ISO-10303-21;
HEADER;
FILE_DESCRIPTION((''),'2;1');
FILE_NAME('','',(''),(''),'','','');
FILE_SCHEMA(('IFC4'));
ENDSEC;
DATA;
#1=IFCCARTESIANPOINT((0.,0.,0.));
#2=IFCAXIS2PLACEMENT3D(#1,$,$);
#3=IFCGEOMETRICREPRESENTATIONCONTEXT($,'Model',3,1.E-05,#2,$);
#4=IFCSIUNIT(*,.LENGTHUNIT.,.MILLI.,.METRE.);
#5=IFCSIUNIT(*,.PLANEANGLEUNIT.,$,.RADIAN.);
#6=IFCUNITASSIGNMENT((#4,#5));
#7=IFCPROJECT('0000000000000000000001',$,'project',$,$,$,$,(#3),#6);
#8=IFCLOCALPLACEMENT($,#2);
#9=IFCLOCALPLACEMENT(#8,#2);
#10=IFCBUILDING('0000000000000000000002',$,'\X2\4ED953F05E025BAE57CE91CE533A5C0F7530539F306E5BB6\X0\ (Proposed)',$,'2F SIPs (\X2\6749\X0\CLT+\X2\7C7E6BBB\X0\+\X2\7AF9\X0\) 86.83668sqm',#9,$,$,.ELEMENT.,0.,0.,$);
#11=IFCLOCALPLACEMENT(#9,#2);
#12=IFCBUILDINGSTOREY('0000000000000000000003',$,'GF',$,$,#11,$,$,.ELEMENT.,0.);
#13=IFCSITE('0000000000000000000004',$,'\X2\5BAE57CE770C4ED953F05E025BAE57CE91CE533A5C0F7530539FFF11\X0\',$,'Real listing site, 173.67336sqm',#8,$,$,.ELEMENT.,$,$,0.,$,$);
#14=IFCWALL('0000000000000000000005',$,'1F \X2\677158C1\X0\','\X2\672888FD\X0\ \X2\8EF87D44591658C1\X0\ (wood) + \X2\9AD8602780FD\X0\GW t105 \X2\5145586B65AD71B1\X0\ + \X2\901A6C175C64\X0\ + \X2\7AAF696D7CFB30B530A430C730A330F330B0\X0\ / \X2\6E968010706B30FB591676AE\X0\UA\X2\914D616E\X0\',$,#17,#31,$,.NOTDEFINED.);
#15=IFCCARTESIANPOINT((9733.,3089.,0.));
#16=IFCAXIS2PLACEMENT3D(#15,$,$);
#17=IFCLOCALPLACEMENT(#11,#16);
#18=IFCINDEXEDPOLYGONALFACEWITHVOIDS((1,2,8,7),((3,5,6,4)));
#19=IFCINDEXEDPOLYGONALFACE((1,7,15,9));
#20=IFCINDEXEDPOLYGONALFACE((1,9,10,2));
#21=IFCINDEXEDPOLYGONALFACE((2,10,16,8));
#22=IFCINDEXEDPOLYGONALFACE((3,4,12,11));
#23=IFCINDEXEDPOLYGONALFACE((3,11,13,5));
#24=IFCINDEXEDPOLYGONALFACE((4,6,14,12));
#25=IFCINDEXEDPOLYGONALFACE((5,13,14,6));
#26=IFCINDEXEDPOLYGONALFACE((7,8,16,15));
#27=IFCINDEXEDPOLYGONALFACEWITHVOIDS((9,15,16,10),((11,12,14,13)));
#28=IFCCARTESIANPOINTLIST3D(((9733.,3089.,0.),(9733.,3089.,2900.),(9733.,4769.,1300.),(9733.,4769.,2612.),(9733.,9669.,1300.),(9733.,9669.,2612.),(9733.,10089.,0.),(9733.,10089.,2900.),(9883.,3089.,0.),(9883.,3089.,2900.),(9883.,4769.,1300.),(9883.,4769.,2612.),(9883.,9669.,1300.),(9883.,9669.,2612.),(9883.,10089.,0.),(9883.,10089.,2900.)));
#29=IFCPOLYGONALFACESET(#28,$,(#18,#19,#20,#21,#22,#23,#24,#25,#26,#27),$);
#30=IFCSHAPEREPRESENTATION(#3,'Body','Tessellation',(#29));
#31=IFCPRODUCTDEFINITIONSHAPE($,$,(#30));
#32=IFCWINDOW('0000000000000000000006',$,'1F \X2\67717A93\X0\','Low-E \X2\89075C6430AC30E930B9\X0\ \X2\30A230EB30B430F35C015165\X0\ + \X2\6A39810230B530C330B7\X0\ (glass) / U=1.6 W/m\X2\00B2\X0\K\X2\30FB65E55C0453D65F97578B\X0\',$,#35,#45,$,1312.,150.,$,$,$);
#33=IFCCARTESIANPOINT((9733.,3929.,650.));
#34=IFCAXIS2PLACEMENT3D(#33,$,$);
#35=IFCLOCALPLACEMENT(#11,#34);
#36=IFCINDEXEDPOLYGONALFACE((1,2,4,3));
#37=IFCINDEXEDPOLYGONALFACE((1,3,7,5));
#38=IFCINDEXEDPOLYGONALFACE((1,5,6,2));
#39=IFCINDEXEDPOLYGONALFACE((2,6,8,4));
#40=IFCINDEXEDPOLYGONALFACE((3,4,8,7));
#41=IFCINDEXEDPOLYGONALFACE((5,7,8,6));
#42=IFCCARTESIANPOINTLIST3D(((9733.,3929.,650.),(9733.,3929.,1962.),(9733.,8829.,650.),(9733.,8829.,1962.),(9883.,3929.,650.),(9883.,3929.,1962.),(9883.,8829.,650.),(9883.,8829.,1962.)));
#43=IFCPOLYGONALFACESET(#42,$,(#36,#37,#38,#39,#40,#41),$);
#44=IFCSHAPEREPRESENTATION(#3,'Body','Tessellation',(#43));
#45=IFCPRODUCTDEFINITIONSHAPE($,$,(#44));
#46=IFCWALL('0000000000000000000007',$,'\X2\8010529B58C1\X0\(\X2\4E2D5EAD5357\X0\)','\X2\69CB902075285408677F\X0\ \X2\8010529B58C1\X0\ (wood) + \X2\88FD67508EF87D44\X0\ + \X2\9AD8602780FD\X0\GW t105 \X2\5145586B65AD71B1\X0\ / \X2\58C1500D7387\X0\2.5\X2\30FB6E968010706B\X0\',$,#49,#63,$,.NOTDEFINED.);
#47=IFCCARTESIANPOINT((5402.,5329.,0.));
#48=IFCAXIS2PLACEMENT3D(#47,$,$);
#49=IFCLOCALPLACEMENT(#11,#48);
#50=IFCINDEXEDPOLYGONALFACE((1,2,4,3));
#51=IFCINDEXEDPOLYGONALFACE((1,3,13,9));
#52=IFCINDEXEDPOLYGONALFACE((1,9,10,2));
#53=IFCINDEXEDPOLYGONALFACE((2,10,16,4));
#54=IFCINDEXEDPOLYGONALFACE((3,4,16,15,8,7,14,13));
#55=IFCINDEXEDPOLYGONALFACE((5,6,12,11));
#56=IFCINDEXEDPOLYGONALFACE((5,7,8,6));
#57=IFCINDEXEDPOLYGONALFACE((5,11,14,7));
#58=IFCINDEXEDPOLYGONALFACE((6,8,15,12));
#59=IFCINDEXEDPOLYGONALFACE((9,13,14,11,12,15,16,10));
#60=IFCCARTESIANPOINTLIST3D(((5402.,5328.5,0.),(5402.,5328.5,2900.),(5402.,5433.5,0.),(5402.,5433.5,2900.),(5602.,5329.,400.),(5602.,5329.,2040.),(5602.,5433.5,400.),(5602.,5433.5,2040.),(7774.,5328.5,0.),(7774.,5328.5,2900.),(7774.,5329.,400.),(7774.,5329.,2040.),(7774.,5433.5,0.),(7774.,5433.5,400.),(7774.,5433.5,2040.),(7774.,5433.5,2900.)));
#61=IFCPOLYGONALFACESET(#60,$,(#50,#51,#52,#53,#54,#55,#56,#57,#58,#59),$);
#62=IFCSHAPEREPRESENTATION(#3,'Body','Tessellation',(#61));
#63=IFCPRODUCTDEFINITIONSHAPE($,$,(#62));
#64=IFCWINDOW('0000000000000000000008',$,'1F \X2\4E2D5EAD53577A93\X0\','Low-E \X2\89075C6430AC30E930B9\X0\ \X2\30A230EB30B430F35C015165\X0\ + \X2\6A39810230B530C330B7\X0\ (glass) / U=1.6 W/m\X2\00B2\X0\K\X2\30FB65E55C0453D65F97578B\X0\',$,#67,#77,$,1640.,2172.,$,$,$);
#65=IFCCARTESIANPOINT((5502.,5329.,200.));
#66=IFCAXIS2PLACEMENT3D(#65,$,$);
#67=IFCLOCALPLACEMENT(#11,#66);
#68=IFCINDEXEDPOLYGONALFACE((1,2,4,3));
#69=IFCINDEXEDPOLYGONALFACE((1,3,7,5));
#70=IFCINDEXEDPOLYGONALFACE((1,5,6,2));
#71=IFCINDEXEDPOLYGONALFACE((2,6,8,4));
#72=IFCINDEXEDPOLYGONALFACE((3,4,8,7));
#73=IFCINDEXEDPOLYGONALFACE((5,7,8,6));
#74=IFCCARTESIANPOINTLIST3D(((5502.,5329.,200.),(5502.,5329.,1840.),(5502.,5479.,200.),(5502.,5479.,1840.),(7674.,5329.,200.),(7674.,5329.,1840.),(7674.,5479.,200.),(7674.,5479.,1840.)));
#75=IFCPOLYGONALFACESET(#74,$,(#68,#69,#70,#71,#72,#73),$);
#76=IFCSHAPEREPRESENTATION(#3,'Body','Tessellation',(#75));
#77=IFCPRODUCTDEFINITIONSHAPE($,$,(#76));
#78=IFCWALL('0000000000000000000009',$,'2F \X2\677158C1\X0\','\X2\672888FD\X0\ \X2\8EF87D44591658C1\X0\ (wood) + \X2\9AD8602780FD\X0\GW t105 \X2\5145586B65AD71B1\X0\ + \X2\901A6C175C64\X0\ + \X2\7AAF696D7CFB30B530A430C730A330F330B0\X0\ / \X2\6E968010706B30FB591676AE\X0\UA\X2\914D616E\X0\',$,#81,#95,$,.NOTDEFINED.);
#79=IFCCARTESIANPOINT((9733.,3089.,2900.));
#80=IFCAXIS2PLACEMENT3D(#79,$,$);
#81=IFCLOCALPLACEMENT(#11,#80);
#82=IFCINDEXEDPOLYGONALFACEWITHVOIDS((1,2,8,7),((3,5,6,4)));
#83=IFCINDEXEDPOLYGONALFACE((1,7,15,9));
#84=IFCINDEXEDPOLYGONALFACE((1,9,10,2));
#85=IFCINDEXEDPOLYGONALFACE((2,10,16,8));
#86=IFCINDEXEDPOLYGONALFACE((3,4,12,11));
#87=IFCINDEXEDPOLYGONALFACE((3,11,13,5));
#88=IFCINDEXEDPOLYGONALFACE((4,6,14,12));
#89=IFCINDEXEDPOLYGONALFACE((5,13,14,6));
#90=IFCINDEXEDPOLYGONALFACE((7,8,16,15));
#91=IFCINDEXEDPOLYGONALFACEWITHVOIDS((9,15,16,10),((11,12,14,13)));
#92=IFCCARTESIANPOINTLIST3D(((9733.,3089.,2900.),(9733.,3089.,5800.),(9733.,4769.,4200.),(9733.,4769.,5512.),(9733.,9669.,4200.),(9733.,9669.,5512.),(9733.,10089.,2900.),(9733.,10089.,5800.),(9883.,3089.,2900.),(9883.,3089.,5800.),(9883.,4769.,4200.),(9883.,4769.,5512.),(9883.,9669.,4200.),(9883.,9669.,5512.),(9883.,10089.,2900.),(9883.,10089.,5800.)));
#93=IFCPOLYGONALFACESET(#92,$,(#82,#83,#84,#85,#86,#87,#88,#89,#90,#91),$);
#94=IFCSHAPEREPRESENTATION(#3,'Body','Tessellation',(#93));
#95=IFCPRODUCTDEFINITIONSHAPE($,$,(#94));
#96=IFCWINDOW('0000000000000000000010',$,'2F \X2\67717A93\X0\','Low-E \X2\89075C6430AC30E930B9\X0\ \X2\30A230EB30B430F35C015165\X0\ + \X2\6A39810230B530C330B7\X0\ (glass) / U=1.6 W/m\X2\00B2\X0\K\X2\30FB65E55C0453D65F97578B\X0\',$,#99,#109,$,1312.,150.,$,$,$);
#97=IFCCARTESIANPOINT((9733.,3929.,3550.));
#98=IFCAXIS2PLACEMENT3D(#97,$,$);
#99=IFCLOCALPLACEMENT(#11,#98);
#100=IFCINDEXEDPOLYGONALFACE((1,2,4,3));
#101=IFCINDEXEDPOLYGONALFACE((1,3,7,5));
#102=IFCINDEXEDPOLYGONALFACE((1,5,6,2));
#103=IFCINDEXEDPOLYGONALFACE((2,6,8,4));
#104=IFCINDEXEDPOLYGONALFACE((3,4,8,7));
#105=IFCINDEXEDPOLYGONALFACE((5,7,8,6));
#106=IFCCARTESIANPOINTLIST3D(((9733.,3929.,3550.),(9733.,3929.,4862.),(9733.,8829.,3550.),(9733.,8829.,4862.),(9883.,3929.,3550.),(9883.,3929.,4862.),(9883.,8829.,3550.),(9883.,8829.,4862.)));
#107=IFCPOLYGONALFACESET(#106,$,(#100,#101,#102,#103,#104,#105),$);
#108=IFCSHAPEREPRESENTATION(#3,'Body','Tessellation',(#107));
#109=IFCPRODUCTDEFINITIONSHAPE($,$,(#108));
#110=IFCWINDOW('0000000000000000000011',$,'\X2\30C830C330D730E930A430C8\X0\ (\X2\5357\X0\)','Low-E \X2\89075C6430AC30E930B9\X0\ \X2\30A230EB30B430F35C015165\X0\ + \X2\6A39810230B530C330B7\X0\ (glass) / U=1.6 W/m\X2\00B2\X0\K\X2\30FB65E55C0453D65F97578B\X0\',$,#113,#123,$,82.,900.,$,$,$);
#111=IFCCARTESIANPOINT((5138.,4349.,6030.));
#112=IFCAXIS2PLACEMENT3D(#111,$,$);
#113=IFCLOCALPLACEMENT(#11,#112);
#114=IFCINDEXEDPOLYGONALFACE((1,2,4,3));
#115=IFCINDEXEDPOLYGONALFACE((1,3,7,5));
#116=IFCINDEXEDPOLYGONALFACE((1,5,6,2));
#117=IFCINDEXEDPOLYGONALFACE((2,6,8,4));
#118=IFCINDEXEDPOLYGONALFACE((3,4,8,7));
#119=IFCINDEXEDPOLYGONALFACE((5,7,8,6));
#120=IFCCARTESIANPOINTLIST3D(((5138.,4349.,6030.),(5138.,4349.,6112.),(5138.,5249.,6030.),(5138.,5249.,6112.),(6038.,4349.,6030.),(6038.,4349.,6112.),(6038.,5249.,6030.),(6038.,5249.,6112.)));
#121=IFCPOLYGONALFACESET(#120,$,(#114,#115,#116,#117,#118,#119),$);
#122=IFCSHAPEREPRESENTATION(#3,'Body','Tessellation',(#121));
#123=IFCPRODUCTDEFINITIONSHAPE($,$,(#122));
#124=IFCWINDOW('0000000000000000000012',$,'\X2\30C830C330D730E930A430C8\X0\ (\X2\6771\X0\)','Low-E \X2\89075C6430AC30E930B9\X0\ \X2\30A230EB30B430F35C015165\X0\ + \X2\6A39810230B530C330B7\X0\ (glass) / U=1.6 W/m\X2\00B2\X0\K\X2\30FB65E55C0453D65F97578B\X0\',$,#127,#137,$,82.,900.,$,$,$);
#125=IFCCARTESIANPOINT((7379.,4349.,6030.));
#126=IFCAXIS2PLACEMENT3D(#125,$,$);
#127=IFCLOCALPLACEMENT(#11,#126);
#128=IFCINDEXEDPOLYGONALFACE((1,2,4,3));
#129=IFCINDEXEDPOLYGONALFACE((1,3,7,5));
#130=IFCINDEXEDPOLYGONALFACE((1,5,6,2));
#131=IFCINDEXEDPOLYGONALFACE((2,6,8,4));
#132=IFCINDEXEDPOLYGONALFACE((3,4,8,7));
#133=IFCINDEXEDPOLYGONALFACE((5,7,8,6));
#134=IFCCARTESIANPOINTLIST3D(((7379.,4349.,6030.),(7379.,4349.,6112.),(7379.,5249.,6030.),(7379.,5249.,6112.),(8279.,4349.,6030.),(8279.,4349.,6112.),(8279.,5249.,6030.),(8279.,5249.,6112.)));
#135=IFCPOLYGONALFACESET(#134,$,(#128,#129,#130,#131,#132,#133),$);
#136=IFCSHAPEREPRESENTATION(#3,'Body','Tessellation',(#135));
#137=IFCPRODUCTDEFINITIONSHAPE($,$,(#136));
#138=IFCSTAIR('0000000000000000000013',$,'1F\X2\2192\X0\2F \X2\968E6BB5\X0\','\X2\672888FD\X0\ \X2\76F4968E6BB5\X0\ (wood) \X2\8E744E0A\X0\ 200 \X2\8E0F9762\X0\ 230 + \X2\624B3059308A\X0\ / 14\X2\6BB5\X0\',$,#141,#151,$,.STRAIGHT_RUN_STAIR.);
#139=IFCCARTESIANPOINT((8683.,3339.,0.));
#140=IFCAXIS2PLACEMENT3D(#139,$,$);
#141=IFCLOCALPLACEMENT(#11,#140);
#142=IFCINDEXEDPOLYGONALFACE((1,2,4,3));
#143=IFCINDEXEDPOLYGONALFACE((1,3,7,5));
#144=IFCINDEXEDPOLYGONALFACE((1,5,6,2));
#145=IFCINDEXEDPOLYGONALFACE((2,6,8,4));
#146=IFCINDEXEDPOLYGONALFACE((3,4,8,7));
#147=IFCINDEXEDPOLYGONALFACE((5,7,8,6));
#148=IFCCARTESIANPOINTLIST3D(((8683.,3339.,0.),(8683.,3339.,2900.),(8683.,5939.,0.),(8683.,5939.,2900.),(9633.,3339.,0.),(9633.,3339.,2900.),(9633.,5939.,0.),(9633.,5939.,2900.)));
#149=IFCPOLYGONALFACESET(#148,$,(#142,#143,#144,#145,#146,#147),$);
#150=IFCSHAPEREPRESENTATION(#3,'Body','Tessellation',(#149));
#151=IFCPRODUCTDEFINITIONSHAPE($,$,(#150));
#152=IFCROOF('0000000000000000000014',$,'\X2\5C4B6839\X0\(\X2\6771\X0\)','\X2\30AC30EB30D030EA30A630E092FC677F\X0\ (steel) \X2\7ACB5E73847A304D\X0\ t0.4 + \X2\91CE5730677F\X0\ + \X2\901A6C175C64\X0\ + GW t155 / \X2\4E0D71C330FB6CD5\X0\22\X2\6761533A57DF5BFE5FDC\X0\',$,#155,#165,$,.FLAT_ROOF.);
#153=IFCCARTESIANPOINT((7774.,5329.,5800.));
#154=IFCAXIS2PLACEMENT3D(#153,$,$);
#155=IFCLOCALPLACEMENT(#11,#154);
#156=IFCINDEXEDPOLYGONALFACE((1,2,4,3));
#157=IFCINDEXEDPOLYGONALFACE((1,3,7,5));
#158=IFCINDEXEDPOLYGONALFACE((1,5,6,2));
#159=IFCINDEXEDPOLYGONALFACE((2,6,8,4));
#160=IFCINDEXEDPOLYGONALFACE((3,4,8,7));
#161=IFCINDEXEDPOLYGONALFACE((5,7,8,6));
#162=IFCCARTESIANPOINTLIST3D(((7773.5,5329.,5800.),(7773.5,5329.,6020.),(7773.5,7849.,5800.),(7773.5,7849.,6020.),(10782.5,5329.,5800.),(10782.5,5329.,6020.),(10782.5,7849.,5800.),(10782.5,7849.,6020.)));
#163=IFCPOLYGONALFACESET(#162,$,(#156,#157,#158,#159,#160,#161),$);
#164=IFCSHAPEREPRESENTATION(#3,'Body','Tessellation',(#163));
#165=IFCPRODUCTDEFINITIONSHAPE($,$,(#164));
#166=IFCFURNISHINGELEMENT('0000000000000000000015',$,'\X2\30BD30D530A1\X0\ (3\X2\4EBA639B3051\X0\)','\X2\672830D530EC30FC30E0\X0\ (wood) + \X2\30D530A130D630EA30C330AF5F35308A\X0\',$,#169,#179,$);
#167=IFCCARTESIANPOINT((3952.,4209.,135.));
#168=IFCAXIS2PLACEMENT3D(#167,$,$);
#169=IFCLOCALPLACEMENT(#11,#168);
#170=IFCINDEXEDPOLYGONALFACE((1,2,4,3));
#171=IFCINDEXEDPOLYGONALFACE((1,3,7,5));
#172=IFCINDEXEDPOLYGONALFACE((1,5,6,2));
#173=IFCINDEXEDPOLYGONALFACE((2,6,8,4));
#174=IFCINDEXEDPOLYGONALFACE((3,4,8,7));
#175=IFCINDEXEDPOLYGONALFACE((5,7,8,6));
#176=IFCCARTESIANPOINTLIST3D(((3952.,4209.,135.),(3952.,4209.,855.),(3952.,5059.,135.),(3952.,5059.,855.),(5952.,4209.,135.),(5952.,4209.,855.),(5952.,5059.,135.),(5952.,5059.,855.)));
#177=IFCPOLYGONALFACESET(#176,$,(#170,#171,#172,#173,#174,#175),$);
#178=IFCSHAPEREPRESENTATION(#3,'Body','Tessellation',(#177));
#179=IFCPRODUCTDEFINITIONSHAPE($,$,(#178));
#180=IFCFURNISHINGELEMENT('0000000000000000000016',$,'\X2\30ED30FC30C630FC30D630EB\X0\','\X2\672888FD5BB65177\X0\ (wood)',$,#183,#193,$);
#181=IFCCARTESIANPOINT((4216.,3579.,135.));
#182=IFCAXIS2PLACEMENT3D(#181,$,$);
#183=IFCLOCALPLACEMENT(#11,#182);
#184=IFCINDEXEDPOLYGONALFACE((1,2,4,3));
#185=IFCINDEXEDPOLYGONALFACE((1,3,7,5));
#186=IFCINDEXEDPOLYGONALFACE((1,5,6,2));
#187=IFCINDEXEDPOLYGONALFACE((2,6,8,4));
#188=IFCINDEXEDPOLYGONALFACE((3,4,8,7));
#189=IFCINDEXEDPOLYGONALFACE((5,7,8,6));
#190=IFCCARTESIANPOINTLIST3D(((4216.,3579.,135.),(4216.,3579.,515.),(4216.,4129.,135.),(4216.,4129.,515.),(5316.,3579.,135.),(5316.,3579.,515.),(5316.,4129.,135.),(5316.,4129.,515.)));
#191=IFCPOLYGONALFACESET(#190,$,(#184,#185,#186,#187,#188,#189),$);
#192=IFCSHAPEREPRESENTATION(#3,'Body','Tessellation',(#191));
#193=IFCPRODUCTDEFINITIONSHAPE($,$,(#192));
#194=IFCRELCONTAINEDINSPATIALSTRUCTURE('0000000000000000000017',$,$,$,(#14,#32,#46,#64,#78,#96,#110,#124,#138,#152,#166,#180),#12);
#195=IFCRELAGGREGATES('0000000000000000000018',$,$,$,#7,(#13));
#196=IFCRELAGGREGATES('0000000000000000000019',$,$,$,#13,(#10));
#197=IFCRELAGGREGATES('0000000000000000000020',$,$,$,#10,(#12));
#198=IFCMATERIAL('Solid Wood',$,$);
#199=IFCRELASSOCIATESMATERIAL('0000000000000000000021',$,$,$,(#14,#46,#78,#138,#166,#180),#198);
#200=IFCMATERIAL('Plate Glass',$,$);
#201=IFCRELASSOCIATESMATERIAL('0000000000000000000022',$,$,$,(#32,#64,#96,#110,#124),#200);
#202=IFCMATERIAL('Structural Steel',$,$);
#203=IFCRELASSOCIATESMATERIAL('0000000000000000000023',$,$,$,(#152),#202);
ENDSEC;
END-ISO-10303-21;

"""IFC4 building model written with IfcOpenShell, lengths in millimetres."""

from ifc_helpers import new_model, si_unit, frame, frame_2d, origin, place, context, project, spatial, rectangle, extrude, material, element, fill, save


model = new_model("IFC4")

# Units and contexts
model_context = context("Model", 3, precision=1e-05, world=origin())
ifc_project = project(units=[si_unit("LENGTHUNIT", "METRE", prefix="MILLI"), si_unit("PLANEANGLEUNIT", "RADIAN")], contexts=[model_context])

# Site, building, storey
site_placement = place(None, origin())
site = spatial("IfcSite", under=ifc_project, at=site_placement, Name="宮城県仙台市宮城野区小田原１", ObjectType="Real listing site, 173.67336sqm", CompositionType="ELEMENT", RefElevation=0.0)
building_placement = place(site_placement, origin())
building = spatial("IfcBuilding", under=site, at=building_placement, Name="仙台市宮城野区小田原の家 (Proposed)", ObjectType="2F SIPs (杉CLT+籾殻+竹) 86.83668sqm", CompositionType="ELEMENT", ElevationOfRefHeight=0.0, ElevationOfTerrain=0.0)
storey_placement = place(building_placement, origin())
storey = spatial("IfcBuildingStorey", under=building, at=storey_placement, Name="GF", CompositionType="ELEMENT", Elevation=0.0)

# Shared definitions
ifc_material_1 = material(Name="Solid Wood")

# Walls, openings, windows
wall_1_placement = place(storey_placement, frame((9733.0, 3089.0, 0.0)))
wall_1 = element("IfcWall", 1, at=wall_1_placement, inside=storey, material=ifc_material_1, Name="1F 東壁", Description="木製 軸組外壁 (wood) + 高性能GW t105 充填断熱 + 通気層 + 窯業系サイディング / 準耐火・外皮UA配慮", PredefinedType="NOTDEFINED", context=model_context, shape_type="SweptSolid", body=[
    extrude(rectangle(XDim=150.0, YDim=7000.0, at=frame_2d((75.0, 3500.0))), frame((9733.0, 3089.0, 0.0)), (0.0, 0.0, 1.0), 2900.0),
])
opening_1_placement = place(storey_placement, frame((9733.0, 3929.0, 650.0)))
opening_1 = element("IfcOpeningElement", 2, at=opening_1_placement, cuts=wall_1, PredefinedType="NOTDEFINED", context=model_context, shape_type="SweptSolid", body=[
    extrude(rectangle(XDim=150.0, YDim=4900.0, at=frame_2d((75.0, 2450.0))), frame((9733.0, 3929.0, 650.0)), (0.0, 0.0, 1.0), 1312.0),
])
ifc_material_2 = material(Name="Plate Glass")
window_1_placement = place(storey_placement, frame((9733.0, 3929.0, 650.0)))
window_1 = element("IfcWindow", 3, at=window_1_placement, inside=storey, material=ifc_material_2, Name="1F 東窓", Description="Low-E 複層ガラス アルゴン封入 + 樹脂サッシ (glass) / U=1.6 W/m²K・日射取得型", OverallHeight=1312.0, OverallWidth=150.0, context=model_context, shape_type="SweptSolid", body=[
    extrude(rectangle(XDim=150.0, YDim=4900.0, at=frame_2d((75.0, 2450.0))), frame((9733.0, 3929.0, 650.0)), (0.0, 0.0, 1.0), 1312.0),
])
fill(opening_1, window_1)
wall_2_placement = place(storey_placement, frame((5402.0, 5329.0, 0.0)))
wall_2 = element("IfcWall", 4, at=wall_2_placement, inside=storey, material=ifc_material_1, Name="耐力壁(中庭南)", Description="構造用合板 耐力壁 (wood) + 製材軸組 + 高性能GW t105 充填断熱 / 壁倍率2.5・準耐火", PredefinedType="NOTDEFINED", context=model_context, shape_type="SweptSolid", body=[
    extrude(rectangle(XDim=2372.0, YDim=105.0, at=frame_2d((1186.0, 52.0))), frame((5402.0, 5329.0, 0.0)), (0.0, 0.0, 1.0), 2900.0),
])
opening_2_placement = place(storey_placement, frame((5502.0, 5329.0, 200.0)))
opening_2 = element("IfcOpeningElement", 5, at=opening_2_placement, cuts=wall_2, PredefinedType="NOTDEFINED", context=model_context, shape_type="SweptSolid", body=[
    extrude(rectangle(XDim=2172.0, YDim=150.0, at=frame_2d((1086.0, 75.0))), frame((5502.0, 5329.0, 200.0)), (0.0, 0.0, 1.0), 1640.0),
])
window_2_placement = place(storey_placement, frame((5502.0, 5329.0, 200.0)))
window_2 = element("IfcWindow", 6, at=window_2_placement, inside=storey, material=ifc_material_2, Name="1F 中庭南窓", Description="Low-E 複層ガラス アルゴン封入 + 樹脂サッシ (glass) / U=1.6 W/m²K・日射取得型", OverallHeight=1640.0, OverallWidth=2172.0, context=model_context, shape_type="SweptSolid", body=[
    extrude(rectangle(XDim=2172.0, YDim=150.0, at=frame_2d((1086.0, 75.0))), frame((5502.0, 5329.0, 200.0)), (0.0, 0.0, 1.0), 1640.0),
])
fill(opening_2, window_2)

# Wall, opening, window
wall_3_placement = place(storey_placement, frame((9733.0, 3089.0, 2900.0)))
wall_3 = element("IfcWall", 7, at=wall_3_placement, inside=storey, material=ifc_material_1, Name="2F 東壁", Description="木製 軸組外壁 (wood) + 高性能GW t105 充填断熱 + 通気層 + 窯業系サイディング / 準耐火・外皮UA配慮", PredefinedType="NOTDEFINED", context=model_context, shape_type="SweptSolid", body=[
    extrude(rectangle(XDim=150.0, YDim=7000.0, at=frame_2d((75.0, 3500.0))), frame((9733.0, 3089.0, 2900.0)), (0.0, 0.0, 1.0), 2900.0),
])
opening_3_placement = place(storey_placement, frame((9733.0, 3929.0, 3550.0)))
opening_3 = element("IfcOpeningElement", 8, at=opening_3_placement, cuts=wall_3, PredefinedType="NOTDEFINED", context=model_context, shape_type="SweptSolid", body=[
    extrude(rectangle(XDim=150.0, YDim=4900.0, at=frame_2d((75.0, 2450.0))), frame((9733.0, 3929.0, 3550.0)), (0.0, 0.0, 1.0), 1312.0),
])
window_3_placement = place(storey_placement, frame((9733.0, 3929.0, 3550.0)))
window_3 = element("IfcWindow", 9, at=window_3_placement, inside=storey, material=ifc_material_2, Name="2F 東窓", Description="Low-E 複層ガラス アルゴン封入 + 樹脂サッシ (glass) / U=1.6 W/m²K・日射取得型", OverallHeight=1312.0, OverallWidth=150.0, context=model_context, shape_type="SweptSolid", body=[
    extrude(rectangle(XDim=150.0, YDim=4900.0, at=frame_2d((75.0, 2450.0))), frame((9733.0, 3929.0, 3550.0)), (0.0, 0.0, 1.0), 1312.0),
])
fill(opening_3, window_3)

# Windows
window_4_placement = place(storey_placement, frame((5138.0, 4349.0, 6030.0)))
element("IfcWindow", 10, at=window_4_placement, inside=storey, material=ifc_material_2, Name="トップライト (南)", Description="Low-E 複層ガラス アルゴン封入 + 樹脂サッシ (glass) / U=1.6 W/m²K・日射取得型", OverallHeight=82.0, OverallWidth=900.0, context=model_context, shape_type="SweptSolid", body=[
    extrude(rectangle(XDim=900.0, YDim=900.0, at=frame_2d((450.0, 450.0))), frame((5138.0, 4349.0, 6030.0)), (0.0, 0.0, 1.0), 82.0),
])
window_5_placement = place(storey_placement, frame((7379.0, 4349.0, 6030.0)))
element("IfcWindow", 11, at=window_5_placement, inside=storey, material=ifc_material_2, Name="トップライト (東)", Description="Low-E 複層ガラス アルゴン封入 + 樹脂サッシ (glass) / U=1.6 W/m²K・日射取得型", OverallHeight=82.0, OverallWidth=900.0, context=model_context, shape_type="SweptSolid", body=[
    extrude(rectangle(XDim=900.0, YDim=900.0, at=frame_2d((450.0, 450.0))), frame((7379.0, 4349.0, 6030.0)), (0.0, 0.0, 1.0), 82.0),
])

# Stair
stair_placement = place(storey_placement, frame((8683.0, 3339.0, 0.0)))
element("IfcStair", 12, at=stair_placement, inside=storey, material=ifc_material_1, Name="1F→2F 階段", Description="木製 直階段 (wood) 蹴上 200 踏面 230 + 手すり / 14段", PredefinedType="STRAIGHT_RUN_STAIR", context=model_context, shape_type="SweptSolid", body=[
    extrude(rectangle(XDim=950.0, YDim=2600.0, at=frame_2d((475.0, 1300.0))), frame((8683.0, 3339.0, 0.0)), (0.0, 0.0, 1.0), 2900.0),
])

# Roof
ifc_material_3 = material(Name="Structural Steel")
roof_placement = place(storey_placement, frame((7774.0, 5329.0, 5800.0)))
element("IfcRoof", 13, at=roof_placement, inside=storey, material=ifc_material_3, Name="屋根(東)", Description="ガルバリウム鋼板 (steel) 立平葺き t0.4 + 野地板 + 通気層 + GW t155 / 不燃・法22条区域対応", PredefinedType="FLAT_ROOF", context=model_context, shape_type="SweptSolid", body=[
    extrude(rectangle(XDim=3009.0, YDim=2520.0, at=frame_2d((1504.0, 1260.0))), frame((7774.0, 5329.0, 5800.0)), (0.0, 0.0, 1.0), 220.0),
])

# Furnishing elements
furnishing_1_placement = place(storey_placement, frame((3952.0, 4209.0, 135.0)))
element("IfcFurnishingElement", 14, at=furnishing_1_placement, inside=storey, material=ifc_material_1, Name="ソファ (3人掛け)", Description="木フレーム (wood) + ファブリック張り", context=model_context, shape_type="SweptSolid", body=[
    extrude(rectangle(XDim=2000.0, YDim=850.0, at=frame_2d((1000.0, 425.0))), frame((3952.0, 4209.0, 135.0)), (0.0, 0.0, 1.0), 720.0),
])
furnishing_2_placement = place(storey_placement, frame((4216.0, 3579.0, 135.0)))
element("IfcFurnishingElement", 15, at=furnishing_2_placement, inside=storey, material=ifc_material_1, Name="ローテーブル", Description="木製家具 (wood)", context=model_context, shape_type="SweptSolid", body=[
    extrude(rectangle(XDim=1100.0, YDim=550.0, at=frame_2d((550.0, 275.0))), frame((4216.0, 3579.0, 135.0)), (0.0, 0.0, 1.0), 380.0),
])

save(model, "model.ifc")
